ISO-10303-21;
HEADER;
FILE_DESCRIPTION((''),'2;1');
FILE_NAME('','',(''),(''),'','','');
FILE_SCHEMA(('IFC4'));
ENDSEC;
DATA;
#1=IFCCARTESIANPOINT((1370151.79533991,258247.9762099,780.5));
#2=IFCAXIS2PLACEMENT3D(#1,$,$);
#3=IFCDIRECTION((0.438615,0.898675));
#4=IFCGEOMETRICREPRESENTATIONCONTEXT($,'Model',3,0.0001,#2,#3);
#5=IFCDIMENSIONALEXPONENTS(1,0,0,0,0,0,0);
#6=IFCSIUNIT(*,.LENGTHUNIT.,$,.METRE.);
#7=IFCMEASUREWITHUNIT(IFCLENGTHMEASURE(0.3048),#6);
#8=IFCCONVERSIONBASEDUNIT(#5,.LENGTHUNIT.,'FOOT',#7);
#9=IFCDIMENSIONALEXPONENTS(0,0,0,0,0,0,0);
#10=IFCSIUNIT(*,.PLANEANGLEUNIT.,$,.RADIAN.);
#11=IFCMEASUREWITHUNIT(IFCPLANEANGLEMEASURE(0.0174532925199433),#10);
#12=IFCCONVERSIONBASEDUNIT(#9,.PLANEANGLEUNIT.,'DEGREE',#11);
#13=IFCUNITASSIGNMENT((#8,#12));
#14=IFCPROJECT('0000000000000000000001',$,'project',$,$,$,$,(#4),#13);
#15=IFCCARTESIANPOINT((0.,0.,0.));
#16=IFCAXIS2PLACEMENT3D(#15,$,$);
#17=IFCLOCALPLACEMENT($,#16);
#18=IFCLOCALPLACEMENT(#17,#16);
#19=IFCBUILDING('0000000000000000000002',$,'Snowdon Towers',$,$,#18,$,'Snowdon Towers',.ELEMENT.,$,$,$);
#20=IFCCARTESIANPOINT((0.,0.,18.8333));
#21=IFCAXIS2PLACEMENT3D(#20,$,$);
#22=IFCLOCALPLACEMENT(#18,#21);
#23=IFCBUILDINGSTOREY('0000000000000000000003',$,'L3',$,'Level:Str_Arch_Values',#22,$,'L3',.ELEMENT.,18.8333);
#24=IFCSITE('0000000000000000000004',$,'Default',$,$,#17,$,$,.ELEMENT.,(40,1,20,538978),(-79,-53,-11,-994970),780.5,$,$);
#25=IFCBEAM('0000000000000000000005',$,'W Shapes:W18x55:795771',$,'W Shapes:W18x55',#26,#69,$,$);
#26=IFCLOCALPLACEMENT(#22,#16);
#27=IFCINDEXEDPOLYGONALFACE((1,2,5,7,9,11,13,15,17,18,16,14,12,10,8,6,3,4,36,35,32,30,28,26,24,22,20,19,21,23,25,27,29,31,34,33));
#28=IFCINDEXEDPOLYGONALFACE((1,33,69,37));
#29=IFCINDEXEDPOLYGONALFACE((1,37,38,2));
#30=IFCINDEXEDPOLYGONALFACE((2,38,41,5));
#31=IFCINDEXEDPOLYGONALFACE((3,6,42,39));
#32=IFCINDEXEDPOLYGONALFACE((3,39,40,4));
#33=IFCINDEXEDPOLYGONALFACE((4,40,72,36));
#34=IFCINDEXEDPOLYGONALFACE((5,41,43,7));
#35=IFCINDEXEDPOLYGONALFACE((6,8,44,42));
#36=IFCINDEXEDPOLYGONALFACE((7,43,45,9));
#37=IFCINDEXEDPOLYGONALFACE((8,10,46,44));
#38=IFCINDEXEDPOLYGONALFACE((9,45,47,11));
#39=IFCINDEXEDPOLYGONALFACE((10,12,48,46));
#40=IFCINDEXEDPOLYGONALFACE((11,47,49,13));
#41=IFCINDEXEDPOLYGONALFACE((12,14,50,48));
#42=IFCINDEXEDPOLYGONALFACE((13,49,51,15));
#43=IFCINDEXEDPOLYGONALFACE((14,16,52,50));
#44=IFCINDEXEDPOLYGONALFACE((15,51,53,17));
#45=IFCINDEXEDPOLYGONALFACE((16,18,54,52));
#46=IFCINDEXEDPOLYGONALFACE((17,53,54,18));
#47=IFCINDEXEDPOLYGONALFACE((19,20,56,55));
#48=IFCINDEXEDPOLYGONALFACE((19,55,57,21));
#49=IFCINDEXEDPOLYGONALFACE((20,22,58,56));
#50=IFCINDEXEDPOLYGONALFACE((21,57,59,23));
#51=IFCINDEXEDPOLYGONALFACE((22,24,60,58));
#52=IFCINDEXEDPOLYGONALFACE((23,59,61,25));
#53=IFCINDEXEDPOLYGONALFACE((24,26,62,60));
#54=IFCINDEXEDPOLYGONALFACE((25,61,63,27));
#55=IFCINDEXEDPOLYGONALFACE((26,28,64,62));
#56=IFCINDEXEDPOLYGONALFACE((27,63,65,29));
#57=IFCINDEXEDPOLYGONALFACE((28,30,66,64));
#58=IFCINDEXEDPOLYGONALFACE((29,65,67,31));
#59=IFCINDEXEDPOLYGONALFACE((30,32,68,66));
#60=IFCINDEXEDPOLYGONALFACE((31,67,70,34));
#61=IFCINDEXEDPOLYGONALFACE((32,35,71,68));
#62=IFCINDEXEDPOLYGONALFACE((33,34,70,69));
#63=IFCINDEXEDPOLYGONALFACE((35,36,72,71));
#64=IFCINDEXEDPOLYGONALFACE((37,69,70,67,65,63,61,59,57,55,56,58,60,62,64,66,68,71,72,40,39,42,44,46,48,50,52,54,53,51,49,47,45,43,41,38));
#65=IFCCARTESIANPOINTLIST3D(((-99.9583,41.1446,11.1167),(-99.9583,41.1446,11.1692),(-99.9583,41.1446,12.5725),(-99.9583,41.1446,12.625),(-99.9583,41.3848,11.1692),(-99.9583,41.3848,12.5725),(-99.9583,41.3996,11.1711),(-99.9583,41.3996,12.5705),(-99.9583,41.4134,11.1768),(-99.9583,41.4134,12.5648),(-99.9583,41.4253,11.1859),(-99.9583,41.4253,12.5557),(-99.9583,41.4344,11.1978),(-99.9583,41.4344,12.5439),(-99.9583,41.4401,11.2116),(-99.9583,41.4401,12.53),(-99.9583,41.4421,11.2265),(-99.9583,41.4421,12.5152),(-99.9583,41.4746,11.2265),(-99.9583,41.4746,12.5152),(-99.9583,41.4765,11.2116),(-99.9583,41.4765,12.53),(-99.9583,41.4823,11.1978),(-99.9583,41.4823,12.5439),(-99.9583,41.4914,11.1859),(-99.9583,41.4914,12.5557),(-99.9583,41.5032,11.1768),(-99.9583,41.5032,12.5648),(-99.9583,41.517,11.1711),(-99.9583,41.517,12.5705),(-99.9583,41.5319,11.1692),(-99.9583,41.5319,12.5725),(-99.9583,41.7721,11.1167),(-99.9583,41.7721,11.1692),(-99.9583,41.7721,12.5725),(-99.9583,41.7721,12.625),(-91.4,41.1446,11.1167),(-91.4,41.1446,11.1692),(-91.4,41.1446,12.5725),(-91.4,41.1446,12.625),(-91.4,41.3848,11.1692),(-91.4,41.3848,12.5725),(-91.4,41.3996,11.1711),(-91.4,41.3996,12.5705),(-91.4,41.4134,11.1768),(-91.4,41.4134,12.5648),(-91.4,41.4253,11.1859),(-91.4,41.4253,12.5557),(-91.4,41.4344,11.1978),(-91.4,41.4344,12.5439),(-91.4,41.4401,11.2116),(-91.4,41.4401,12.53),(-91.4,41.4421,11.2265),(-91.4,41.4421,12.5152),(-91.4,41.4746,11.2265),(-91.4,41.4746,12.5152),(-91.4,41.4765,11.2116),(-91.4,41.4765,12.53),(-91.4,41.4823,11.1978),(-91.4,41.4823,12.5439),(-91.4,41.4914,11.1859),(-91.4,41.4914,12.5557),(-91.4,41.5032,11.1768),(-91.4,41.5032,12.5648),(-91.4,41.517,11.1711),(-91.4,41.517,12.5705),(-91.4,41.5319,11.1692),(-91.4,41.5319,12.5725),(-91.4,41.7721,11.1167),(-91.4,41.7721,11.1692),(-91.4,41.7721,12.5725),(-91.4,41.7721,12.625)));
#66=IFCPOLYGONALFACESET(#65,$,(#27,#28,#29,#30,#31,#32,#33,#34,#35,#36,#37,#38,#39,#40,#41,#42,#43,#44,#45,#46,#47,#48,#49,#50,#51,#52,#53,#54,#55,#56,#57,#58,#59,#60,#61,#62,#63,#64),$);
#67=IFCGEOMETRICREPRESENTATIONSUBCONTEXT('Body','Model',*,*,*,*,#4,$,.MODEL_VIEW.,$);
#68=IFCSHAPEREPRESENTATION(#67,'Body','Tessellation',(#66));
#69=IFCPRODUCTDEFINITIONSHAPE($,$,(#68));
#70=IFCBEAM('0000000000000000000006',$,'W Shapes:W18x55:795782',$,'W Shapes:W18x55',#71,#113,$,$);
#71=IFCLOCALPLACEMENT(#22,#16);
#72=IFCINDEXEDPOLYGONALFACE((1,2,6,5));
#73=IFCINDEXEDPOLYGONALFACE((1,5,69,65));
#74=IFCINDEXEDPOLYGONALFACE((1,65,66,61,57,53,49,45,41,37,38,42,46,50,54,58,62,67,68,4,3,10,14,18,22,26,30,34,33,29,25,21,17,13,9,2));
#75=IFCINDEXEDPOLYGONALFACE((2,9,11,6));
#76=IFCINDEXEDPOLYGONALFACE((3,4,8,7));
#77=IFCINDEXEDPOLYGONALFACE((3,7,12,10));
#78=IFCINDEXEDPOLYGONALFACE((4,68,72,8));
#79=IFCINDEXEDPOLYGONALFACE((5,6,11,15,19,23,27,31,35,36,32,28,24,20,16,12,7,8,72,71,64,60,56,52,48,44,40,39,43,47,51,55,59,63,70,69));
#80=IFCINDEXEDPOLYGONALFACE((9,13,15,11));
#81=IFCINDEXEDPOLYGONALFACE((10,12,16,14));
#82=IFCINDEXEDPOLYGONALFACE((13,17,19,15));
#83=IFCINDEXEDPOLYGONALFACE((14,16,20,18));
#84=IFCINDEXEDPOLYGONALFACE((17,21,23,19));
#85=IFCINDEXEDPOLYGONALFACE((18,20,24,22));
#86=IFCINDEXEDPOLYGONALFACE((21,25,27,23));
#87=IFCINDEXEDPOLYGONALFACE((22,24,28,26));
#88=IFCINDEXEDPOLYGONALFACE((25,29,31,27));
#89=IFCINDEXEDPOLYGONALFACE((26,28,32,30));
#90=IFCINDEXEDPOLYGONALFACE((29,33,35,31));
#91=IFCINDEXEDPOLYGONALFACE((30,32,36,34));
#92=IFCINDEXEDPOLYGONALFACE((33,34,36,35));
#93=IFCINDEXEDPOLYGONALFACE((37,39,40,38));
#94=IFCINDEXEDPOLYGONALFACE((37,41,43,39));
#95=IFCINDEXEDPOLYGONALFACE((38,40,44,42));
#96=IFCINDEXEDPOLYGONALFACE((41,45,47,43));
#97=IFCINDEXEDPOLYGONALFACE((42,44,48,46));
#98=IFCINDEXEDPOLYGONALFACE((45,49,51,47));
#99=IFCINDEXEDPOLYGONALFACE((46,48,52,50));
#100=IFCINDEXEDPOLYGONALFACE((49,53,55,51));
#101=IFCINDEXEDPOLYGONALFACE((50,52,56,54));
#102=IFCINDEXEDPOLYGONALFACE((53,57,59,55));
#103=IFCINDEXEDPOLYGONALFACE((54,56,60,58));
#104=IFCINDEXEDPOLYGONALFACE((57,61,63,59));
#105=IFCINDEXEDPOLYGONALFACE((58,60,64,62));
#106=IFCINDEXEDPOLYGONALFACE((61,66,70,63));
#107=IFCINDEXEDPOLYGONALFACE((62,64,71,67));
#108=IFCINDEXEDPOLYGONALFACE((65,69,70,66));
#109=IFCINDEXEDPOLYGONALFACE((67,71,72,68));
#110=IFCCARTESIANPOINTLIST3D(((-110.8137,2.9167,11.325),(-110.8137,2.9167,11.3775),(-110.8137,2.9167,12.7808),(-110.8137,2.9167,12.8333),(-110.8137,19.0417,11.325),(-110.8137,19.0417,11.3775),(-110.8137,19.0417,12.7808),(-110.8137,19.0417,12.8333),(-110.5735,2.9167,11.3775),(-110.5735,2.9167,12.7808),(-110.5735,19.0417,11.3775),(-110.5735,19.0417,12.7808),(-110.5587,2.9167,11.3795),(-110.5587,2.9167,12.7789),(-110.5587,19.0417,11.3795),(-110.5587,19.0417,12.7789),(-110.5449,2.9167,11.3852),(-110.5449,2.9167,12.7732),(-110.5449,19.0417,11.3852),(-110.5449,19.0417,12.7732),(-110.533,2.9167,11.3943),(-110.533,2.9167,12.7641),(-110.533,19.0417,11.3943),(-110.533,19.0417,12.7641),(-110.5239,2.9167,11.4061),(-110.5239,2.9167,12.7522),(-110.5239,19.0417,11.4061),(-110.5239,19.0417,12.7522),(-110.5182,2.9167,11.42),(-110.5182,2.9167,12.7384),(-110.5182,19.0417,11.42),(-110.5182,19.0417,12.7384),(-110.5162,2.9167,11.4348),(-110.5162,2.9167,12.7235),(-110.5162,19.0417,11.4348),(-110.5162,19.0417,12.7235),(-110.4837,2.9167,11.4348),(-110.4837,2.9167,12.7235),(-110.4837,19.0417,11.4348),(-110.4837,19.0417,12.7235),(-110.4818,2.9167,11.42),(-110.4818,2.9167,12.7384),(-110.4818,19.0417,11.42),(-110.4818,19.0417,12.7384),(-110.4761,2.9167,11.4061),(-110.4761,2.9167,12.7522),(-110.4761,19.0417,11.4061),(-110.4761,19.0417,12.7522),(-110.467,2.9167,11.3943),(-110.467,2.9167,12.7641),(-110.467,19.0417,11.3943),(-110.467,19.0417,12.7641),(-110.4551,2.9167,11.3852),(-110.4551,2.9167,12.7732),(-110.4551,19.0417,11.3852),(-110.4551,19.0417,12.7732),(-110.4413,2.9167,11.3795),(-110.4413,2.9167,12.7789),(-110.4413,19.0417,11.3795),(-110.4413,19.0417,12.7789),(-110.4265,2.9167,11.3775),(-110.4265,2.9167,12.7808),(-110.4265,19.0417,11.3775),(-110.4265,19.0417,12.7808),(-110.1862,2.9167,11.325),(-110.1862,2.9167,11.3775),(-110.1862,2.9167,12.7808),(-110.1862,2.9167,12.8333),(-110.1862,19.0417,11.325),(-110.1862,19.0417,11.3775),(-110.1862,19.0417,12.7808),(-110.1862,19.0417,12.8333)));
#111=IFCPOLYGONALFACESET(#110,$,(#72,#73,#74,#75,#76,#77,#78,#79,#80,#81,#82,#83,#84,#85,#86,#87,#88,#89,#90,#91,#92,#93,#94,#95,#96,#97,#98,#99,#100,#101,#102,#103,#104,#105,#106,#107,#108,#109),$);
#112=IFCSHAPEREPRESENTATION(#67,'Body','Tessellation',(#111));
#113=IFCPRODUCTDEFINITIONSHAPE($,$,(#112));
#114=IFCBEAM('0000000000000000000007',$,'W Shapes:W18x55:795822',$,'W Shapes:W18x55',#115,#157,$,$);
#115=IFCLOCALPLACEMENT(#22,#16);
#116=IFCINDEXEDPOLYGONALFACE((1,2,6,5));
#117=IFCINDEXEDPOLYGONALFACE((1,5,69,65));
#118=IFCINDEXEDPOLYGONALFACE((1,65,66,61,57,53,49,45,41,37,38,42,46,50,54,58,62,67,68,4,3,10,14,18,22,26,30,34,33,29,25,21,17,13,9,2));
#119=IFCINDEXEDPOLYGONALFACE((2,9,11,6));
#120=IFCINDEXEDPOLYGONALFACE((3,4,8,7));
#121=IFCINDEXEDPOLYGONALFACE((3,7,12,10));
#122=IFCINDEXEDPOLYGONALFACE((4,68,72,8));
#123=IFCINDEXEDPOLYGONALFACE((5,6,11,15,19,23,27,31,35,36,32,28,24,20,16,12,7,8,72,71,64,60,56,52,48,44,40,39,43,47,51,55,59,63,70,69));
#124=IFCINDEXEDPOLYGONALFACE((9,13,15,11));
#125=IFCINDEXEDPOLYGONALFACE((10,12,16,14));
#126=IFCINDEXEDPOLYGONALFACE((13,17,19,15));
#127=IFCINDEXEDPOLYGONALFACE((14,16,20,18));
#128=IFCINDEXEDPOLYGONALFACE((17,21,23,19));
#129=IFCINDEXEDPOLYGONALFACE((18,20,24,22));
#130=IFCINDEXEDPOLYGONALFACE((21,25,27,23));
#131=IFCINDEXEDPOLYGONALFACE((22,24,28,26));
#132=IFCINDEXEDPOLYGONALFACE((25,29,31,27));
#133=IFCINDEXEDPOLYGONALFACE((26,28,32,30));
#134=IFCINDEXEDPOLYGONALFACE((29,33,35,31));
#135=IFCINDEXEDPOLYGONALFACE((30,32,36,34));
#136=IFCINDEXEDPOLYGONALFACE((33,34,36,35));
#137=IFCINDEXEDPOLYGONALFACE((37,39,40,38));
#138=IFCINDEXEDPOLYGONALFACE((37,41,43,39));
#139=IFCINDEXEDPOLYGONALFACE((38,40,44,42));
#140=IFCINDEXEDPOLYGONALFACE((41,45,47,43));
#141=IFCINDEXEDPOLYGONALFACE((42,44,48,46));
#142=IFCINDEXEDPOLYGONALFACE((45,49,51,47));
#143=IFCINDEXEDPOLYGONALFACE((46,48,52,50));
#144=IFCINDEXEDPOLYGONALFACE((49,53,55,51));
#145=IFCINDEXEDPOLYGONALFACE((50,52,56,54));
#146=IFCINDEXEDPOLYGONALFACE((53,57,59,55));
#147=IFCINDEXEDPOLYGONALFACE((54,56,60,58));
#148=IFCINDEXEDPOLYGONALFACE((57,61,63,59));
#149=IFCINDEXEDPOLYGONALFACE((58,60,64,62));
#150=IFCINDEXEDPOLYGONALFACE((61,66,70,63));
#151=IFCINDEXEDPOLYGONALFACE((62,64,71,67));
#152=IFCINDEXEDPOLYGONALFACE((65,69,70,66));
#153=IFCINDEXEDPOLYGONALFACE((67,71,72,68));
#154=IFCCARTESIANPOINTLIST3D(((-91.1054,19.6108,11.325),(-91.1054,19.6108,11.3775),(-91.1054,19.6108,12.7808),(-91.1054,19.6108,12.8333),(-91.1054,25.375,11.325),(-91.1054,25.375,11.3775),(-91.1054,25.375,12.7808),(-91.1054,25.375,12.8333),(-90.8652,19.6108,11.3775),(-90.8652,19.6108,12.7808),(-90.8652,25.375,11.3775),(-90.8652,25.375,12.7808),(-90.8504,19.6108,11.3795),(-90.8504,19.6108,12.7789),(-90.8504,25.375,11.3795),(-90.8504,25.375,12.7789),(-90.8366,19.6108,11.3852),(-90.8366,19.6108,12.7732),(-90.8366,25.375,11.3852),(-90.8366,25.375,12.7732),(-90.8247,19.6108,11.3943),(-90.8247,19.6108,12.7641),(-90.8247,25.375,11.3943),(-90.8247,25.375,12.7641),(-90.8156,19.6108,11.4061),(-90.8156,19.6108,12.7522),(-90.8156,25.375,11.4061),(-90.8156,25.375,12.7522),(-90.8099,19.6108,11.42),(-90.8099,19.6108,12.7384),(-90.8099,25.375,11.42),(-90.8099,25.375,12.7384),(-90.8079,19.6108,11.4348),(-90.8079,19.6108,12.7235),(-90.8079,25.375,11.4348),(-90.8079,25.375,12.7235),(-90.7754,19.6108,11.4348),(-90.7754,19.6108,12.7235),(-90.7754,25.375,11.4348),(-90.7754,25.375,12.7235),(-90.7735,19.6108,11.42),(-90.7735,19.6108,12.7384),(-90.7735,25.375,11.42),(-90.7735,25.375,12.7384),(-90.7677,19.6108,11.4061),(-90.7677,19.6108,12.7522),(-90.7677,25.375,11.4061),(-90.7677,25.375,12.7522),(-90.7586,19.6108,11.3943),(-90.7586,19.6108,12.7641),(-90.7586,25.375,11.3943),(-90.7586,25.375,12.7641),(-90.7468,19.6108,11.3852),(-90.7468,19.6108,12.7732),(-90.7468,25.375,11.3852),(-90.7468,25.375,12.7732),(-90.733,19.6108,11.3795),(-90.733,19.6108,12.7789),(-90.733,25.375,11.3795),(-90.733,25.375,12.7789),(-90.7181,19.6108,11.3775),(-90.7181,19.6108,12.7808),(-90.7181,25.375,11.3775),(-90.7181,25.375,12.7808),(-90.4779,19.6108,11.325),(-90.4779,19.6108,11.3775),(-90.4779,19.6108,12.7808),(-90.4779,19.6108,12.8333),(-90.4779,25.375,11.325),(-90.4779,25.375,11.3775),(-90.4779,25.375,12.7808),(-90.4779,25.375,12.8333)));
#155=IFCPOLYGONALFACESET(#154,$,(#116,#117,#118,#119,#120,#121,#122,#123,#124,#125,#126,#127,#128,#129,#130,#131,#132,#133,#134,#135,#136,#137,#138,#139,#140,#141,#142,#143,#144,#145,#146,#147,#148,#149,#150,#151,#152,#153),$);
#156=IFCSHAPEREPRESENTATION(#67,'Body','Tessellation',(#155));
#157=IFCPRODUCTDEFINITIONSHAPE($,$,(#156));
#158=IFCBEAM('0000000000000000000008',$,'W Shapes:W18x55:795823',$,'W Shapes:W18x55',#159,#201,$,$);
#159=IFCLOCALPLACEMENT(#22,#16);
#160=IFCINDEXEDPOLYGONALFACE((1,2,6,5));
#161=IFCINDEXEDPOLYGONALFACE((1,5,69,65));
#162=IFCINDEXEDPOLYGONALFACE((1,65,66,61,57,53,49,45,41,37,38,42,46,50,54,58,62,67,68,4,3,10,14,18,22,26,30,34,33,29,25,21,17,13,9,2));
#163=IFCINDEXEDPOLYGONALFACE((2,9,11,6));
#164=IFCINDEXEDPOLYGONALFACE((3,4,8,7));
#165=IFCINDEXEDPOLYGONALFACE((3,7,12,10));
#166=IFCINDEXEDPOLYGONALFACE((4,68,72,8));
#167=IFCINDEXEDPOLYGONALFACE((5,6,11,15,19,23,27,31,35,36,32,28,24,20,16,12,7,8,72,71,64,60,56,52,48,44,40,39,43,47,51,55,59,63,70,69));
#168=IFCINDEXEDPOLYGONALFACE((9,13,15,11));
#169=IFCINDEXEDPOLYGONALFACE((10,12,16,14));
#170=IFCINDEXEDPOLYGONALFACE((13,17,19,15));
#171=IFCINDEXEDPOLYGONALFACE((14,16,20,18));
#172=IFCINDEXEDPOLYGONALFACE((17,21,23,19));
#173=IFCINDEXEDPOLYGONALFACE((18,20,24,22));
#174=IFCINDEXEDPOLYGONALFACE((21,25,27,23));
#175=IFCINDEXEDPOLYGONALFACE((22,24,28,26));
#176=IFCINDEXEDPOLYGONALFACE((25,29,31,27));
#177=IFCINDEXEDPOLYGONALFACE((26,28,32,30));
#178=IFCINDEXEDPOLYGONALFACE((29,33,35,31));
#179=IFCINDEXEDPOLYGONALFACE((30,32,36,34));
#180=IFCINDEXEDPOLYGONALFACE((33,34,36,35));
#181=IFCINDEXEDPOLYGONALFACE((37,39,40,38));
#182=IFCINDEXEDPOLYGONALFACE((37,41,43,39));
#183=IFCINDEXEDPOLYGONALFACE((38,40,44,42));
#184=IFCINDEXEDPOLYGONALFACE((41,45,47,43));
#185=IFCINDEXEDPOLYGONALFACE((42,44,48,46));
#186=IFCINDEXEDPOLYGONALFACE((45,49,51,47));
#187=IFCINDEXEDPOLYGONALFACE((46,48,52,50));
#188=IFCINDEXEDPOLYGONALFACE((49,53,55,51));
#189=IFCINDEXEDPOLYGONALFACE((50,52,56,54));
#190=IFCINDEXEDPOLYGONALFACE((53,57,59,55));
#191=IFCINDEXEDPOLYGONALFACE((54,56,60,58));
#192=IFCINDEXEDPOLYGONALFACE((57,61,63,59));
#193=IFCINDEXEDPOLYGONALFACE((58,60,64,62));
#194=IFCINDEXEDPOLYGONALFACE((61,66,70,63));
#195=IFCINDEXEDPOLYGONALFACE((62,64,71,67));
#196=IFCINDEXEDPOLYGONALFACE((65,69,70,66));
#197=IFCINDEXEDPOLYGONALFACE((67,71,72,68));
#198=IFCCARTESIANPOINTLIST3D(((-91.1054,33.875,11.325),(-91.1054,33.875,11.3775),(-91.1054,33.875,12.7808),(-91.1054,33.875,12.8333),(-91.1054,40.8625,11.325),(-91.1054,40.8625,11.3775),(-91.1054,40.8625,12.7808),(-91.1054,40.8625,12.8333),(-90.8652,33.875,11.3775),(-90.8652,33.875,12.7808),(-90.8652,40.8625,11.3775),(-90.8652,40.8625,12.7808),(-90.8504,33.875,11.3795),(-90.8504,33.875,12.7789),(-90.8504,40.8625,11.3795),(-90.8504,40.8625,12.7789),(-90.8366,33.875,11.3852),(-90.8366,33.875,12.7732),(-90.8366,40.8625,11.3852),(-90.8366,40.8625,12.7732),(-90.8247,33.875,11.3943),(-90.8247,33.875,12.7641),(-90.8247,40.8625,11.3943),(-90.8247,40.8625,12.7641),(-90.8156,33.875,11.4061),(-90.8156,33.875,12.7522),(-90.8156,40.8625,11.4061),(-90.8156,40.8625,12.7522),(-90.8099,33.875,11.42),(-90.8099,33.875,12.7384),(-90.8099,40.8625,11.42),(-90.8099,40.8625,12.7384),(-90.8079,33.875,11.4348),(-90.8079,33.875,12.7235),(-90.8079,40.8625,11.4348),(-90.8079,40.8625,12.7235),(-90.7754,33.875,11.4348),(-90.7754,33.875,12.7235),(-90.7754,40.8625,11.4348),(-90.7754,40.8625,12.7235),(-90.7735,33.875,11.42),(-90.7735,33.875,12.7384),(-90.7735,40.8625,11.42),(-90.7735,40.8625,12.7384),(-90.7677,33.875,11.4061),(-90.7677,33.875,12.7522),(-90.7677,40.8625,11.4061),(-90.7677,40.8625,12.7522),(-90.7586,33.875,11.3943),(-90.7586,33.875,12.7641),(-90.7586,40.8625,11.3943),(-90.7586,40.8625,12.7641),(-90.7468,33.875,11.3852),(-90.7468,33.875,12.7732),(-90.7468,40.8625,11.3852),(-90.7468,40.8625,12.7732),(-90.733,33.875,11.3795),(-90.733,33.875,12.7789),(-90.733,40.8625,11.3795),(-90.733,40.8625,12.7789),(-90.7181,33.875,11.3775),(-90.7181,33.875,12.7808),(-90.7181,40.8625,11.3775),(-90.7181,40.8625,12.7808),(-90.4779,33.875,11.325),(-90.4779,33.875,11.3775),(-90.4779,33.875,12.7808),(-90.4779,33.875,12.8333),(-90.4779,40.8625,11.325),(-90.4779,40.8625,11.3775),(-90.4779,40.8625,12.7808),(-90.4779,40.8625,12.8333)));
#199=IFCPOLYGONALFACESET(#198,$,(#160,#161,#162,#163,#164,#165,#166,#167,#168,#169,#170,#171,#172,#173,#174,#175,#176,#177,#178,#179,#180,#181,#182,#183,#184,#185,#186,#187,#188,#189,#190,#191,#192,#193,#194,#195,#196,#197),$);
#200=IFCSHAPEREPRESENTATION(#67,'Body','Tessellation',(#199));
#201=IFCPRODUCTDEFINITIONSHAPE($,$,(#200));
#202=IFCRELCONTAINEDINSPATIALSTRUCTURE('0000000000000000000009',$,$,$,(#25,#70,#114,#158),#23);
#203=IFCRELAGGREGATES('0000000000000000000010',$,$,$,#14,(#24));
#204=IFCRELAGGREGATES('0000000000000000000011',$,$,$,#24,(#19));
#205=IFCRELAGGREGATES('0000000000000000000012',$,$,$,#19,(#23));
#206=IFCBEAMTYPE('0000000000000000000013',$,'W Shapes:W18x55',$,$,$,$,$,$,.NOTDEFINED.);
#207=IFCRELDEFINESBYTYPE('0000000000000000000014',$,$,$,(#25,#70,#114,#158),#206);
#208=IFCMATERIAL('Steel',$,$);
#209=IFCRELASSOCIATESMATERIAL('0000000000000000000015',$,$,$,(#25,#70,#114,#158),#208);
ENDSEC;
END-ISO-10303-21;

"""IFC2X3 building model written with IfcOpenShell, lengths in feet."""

from ifc_helpers import new_model, entity, si_unit, converted_unit, direction, frame, frame_2d, origin, place, context, subcontext, project, spatial, i_section, extrude, material, type_object, element, save


model = new_model("IFC2X3")

# Units and contexts
model_context = context("Model", 3, precision=0.0001, world=frame((1370151.79533991, 258247.9762099, 780.5)), true_north=direction((0.438615, 0.898675)))
body_context = subcontext(model_context, "Body", "Model", "MODEL_VIEW")
ifc_project = project(units=[converted_unit("LENGTHUNIT", "FOOT", entity("IfcLengthMeasure", 0.3048), si_unit("LENGTHUNIT", "METRE"), dimensions=[1, 0, 0, 0, 0, 0, 0]), converted_unit("PLANEANGLEUNIT", "DEGREE", entity("IfcPlaneAngleMeasure", 0.0174532925199433), si_unit("PLANEANGLEUNIT", "RADIAN"), dimensions=[0, 0, 0, 0, 0, 0, 0])], contexts=[model_context])

# Site, building, storey
site_placement = place(None, origin())
site = spatial("IfcSite", under=ifc_project, at=site_placement, Name="Default", CompositionType="ELEMENT", RefLatitude=(40, 1, 20, 538978), RefLongitude=(-79, -53, -11, -994970), RefElevation=780.5)
building_placement = place(site_placement, origin())
building = spatial("IfcBuilding", under=site, at=building_placement, Name="Snowdon Towers", LongName="Snowdon Towers", CompositionType="ELEMENT")
storey_placement = place(building_placement, frame((0.0, 0.0, 18.8333)))
storey = spatial("IfcBuildingStorey", under=building, at=storey_placement, Name="L3", ObjectType="Level:Str_Arch_Values", LongName="L3", CompositionType="ELEMENT", Elevation=18.8333)

# Shared definitions
ifc_material_1 = material(Name="Steel")

# Beams
beam_type_1 = type_object("IfcBeamType", Name="W Shapes:W18x55", PredefinedType="NOTDEFINED")
beam_1_placement = place(storey_placement, frame((-99.9583, 41.4583, 12.8333)))
element("IfcBeam", 1, at=beam_1_placement, inside=storey, type_object=beam_type_1, material=ifc_material_1, Name="W Shapes:W18x55:795771", ObjectType="W Shapes:W18x55", context=body_context, shape_type="SweptSolid", body=[
    extrude(i_section(OverallWidth=0.6275, OverallDepth=1.5083, WebThickness=0.0325, FlangeThickness=0.0525, FilletRadius=0.0573, at=frame_2d((0.0, 0.0), x_axis=(0.0, 1.0))), frame((0.0, 0.0, -0.9625), z_axis=(1.0, 0.0, 0.0), x_axis=(0.0, 0.0, -1.0)), (0.0, 0.0, 1.0), 8.5583),
])
beam_2_placement = place(storey_placement, frame((-110.5, 2.5, 12.8333), z_axis=(0.0, 0.0, 1.0), x_axis=(0.0, 1.0, 0.0)))
element("IfcBeam", 2, at=beam_2_placement, inside=storey, type_object=beam_type_1, material=ifc_material_1, Name="W Shapes:W18x55:795782", ObjectType="W Shapes:W18x55", context=body_context, shape_type="SweptSolid", body=[
    extrude(i_section(OverallWidth=0.6275, OverallDepth=1.5083, WebThickness=0.0325, FlangeThickness=0.0525, FilletRadius=0.0573, at=frame_2d((0.0, 0.0), x_axis=(0.0, 1.0))), frame((0.4167, 0.0, -0.7542), z_axis=(1.0, 0.0, 0.0), x_axis=(0.0, 0.0, -1.0)), (0.0, 0.0, 1.0), 16.125),
])
beam_3_placement = place(storey_placement, frame((-90.7917, 19.1942, 12.8333), z_axis=(0.0, 0.0, 1.0), x_axis=(0.0, 1.0, 0.0)))
element("IfcBeam", 3, at=beam_3_placement, inside=storey, type_object=beam_type_1, material=ifc_material_1, Name="W Shapes:W18x55:795822", ObjectType="W Shapes:W18x55", context=body_context, shape_type="SweptSolid", body=[
    extrude(i_section(OverallWidth=0.6275, OverallDepth=1.5083, WebThickness=0.0325, FlangeThickness=0.0525, FilletRadius=0.0573, at=frame_2d((0.0, 0.0), x_axis=(0.0, 1.0))), frame((0.4167, 0.0, -0.7542), z_axis=(1.0, 0.0, 0.0), x_axis=(0.0, 0.0, -1.0)), (0.0, 0.0, 1.0), 5.7642),
])
beam_4_placement = place(storey_placement, frame((-90.7917, 41.4583, 12.8333), z_axis=(0.0, 0.0, 1.0), x_axis=(0.0, -1.0, 0.0)))
element("IfcBeam", 4, at=beam_4_placement, inside=storey, type_object=beam_type_1, material=ifc_material_1, Name="W Shapes:W18x55:795823", ObjectType="W Shapes:W18x55", context=body_context, shape_type="SweptSolid", body=[
    extrude(i_section(OverallWidth=0.6275, OverallDepth=1.5083, WebThickness=0.0325, FlangeThickness=0.0525, FilletRadius=0.0573, at=frame_2d((0.0, 0.0), x_axis=(0.0, 1.0))), frame((0.5958, 0.0, -0.7542), z_axis=(1.0, 0.0, 0.0), x_axis=(0.0, 0.0, -1.0)), (0.0, 0.0, 1.0), 6.9875),
])

save(model, "model.ifc")
